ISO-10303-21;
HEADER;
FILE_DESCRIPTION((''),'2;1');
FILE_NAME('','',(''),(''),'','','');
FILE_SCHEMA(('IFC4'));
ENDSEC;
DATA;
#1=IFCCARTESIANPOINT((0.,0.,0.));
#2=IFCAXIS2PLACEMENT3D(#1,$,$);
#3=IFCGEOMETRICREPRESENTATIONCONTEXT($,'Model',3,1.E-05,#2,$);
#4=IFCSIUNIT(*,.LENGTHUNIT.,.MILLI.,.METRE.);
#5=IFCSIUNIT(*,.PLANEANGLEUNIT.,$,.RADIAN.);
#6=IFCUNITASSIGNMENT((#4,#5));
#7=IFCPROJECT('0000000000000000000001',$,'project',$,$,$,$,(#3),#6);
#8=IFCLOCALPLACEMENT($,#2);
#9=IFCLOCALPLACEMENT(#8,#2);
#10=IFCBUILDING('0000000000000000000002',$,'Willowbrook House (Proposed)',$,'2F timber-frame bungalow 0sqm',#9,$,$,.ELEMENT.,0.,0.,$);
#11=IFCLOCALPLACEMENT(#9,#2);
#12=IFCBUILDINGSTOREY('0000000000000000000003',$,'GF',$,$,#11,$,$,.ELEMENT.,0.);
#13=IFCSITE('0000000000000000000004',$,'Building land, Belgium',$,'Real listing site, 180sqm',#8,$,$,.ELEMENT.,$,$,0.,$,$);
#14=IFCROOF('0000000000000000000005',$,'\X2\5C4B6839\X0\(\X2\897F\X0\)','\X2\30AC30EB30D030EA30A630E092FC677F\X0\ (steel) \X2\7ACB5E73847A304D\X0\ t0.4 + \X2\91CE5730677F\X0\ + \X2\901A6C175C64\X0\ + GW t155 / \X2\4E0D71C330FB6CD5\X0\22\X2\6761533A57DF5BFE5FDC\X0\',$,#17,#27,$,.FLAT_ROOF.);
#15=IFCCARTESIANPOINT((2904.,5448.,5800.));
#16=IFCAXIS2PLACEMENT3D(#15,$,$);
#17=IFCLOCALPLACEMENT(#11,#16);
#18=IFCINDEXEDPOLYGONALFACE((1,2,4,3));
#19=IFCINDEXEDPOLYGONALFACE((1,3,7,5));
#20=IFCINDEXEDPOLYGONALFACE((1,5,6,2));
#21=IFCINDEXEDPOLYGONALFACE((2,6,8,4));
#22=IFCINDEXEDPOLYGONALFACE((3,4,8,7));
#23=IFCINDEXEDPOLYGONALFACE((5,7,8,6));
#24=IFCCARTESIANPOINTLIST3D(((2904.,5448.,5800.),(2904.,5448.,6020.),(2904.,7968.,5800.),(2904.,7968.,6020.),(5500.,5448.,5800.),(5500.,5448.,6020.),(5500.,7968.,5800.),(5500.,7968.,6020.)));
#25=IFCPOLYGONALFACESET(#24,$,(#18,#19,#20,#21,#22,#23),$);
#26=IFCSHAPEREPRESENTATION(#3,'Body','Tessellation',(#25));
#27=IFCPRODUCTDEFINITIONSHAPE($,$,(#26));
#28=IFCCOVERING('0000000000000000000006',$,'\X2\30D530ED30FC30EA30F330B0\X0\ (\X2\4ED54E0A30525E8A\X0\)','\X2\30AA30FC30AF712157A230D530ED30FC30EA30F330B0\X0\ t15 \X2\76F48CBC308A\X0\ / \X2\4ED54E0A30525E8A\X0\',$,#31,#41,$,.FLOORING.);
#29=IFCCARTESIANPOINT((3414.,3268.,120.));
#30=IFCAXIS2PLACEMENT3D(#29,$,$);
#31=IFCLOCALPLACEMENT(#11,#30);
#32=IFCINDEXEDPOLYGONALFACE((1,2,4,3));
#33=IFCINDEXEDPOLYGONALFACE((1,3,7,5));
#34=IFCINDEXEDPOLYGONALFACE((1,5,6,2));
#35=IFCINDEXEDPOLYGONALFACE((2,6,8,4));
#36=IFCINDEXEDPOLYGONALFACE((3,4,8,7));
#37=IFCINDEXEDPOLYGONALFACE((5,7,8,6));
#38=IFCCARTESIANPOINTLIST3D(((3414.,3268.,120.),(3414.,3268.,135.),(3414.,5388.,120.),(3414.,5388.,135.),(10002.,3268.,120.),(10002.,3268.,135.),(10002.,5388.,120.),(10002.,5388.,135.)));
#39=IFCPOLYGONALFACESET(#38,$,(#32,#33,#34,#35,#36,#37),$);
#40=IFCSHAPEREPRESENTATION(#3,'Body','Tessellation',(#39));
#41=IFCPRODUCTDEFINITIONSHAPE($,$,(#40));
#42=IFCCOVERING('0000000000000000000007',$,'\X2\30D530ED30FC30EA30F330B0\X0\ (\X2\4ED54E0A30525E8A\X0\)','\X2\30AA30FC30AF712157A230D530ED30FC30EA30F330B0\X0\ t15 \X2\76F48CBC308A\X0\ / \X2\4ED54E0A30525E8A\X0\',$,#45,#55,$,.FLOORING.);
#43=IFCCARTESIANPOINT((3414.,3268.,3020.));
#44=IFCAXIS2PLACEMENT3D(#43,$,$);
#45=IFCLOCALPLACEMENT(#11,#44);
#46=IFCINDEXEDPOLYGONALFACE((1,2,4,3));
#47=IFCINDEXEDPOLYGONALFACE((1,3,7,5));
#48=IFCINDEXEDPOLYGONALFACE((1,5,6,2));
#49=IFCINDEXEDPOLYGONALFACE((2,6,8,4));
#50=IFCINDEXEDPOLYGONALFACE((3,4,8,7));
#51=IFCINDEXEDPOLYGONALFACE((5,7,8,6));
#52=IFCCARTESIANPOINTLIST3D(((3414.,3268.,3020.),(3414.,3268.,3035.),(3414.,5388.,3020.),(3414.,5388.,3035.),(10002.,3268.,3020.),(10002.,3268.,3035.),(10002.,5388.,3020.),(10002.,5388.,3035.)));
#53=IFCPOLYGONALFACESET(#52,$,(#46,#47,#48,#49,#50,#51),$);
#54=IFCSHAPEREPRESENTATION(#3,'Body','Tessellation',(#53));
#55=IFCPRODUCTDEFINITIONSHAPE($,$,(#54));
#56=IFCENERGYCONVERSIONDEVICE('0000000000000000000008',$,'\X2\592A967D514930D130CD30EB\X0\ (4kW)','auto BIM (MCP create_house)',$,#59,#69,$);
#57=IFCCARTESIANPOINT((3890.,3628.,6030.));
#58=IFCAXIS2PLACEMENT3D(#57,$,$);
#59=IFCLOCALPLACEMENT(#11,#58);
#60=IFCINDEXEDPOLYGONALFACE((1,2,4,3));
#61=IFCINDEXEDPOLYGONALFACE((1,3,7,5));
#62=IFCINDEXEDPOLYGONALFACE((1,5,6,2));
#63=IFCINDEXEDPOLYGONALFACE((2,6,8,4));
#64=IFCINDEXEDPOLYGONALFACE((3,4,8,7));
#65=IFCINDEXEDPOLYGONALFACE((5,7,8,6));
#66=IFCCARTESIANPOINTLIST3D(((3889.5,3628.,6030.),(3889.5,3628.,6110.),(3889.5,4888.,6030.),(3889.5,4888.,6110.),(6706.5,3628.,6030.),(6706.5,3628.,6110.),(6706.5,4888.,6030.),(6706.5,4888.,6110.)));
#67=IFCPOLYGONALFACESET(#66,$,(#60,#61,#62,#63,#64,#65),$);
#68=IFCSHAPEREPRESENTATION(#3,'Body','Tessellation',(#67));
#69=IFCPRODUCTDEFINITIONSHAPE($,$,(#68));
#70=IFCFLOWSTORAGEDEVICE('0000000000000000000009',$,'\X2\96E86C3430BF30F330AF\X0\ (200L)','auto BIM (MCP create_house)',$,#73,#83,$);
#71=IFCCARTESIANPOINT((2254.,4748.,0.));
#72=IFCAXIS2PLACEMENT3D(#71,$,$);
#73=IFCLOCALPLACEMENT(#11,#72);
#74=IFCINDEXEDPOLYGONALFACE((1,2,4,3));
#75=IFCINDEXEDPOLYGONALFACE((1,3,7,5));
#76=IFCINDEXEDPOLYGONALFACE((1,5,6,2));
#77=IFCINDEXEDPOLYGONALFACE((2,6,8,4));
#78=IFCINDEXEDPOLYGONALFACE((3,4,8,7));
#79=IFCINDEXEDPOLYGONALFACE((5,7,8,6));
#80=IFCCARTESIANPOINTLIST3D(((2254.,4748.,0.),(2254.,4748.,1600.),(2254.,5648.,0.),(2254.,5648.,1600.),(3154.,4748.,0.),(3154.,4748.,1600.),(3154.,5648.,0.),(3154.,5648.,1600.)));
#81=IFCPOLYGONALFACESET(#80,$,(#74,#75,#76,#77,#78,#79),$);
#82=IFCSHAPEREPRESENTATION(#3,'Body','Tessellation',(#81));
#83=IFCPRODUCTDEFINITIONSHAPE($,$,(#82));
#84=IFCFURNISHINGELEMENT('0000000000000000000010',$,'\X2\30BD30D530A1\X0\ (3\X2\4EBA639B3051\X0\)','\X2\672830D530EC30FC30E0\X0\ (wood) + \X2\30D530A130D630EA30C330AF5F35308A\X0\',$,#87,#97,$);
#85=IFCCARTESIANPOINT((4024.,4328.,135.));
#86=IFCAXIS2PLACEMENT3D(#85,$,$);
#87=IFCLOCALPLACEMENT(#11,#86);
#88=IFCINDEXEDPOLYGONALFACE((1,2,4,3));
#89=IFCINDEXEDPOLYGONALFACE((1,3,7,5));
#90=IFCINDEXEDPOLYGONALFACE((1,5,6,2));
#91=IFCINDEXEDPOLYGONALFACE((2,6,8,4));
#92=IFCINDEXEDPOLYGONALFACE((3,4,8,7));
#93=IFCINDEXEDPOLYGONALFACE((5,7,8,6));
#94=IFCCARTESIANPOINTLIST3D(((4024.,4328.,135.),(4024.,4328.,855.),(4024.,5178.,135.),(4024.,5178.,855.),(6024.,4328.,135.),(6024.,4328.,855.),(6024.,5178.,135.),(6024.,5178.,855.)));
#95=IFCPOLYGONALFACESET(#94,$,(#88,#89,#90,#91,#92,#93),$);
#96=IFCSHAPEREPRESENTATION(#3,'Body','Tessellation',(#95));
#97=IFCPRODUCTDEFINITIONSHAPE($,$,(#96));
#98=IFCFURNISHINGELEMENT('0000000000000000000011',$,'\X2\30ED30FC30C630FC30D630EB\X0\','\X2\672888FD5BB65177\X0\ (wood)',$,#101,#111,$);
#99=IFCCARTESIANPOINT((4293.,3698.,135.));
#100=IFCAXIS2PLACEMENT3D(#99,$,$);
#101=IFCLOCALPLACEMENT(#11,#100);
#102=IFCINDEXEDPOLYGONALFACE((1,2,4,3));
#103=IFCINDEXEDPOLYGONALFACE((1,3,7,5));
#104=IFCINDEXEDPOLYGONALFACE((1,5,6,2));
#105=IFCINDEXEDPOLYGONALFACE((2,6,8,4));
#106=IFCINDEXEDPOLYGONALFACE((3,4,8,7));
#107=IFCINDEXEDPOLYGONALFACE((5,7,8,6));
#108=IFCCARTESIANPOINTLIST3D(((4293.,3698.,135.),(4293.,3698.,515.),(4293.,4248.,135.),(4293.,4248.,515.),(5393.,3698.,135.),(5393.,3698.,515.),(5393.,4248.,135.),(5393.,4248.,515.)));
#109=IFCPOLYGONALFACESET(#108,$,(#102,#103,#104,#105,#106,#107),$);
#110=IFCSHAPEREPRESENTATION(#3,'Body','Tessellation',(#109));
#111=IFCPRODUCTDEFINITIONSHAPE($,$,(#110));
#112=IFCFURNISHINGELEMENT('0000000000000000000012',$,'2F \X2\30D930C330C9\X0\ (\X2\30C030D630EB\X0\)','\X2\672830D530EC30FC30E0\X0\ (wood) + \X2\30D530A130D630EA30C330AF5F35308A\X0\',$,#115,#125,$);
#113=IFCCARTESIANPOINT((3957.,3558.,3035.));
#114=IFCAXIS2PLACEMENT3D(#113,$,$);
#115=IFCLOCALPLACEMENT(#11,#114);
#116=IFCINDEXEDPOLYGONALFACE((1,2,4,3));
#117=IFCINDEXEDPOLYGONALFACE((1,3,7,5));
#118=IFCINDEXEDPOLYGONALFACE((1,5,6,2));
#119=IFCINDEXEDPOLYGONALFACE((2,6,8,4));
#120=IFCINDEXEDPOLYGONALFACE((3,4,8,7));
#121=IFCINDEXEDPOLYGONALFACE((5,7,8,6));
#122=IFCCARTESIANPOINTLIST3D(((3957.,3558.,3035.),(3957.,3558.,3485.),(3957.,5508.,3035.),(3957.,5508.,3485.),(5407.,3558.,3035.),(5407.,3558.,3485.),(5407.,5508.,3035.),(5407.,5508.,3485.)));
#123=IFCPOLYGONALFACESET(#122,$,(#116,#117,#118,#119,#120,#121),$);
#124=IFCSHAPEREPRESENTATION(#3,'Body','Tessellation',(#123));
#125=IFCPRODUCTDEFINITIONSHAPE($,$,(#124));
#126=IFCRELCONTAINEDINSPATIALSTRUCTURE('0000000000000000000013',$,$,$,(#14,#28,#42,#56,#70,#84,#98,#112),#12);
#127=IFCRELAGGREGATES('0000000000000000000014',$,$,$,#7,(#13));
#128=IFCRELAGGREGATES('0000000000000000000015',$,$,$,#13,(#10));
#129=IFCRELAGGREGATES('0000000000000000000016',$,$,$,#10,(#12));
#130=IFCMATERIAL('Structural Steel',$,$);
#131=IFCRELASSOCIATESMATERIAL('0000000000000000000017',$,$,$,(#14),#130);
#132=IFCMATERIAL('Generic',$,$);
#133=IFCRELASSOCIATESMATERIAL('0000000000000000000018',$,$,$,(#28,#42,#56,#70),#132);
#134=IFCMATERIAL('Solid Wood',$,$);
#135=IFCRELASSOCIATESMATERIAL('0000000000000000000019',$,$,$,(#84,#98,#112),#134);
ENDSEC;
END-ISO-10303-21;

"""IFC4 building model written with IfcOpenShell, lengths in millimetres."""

from ifc_helpers import new_model, si_unit, frame, frame_2d, origin, place, context, project, spatial, rectangle, extrude, material, element, save


model = new_model("IFC4")

# Units and contexts
model_context = context("Model", 3, precision=1e-05, world=origin())
ifc_project = project(units=[si_unit("LENGTHUNIT", "METRE", prefix="MILLI"), si_unit("PLANEANGLEUNIT", "RADIAN")], contexts=[model_context])

# Site, building, storey
site_placement = place(None, origin())
site = spatial("IfcSite", under=ifc_project, at=site_placement, Name="Building land, Belgium", ObjectType="Real listing site, 180sqm", CompositionType="ELEMENT", RefElevation=0.0)
building_placement = place(site_placement, origin())
building = spatial("IfcBuilding", under=site, at=building_placement, Name="Willowbrook House (Proposed)", ObjectType="2F timber-frame bungalow 0sqm", CompositionType="ELEMENT", ElevationOfRefHeight=0.0, ElevationOfTerrain=0.0)
storey_placement = place(building_placement, origin())
storey = spatial("IfcBuildingStorey", under=building, at=storey_placement, Name="GF", CompositionType="ELEMENT", Elevation=0.0)

# Shared definitions
ifc_material_1 = material(Name="Solid Wood")

# Roof
ifc_material_2 = material(Name="Structural Steel")
roof_1_placement = place(storey_placement, frame((2904.0, 5448.0, 5800.0)))
element("IfcRoof", 1, at=roof_1_placement, inside=storey, material=ifc_material_2, Name="屋根(西)", Description="ガルバリウム鋼板 (steel) 立平葺き t0.4 + 野地板 + 通気層 + GW t155 / 不燃・法22条区域対応", PredefinedType="FLAT_ROOF", context=model_context, shape_type="SweptSolid", body=[
    extrude(rectangle(XDim=2596.0, YDim=2520.0, at=frame_2d((1298.0, 1260.0))), frame((2904.0, 5448.0, 5800.0)), (0.0, 0.0, 1.0), 220.0),
])

# Coverings
ifc_material_3 = material(Name="Generic")
covering_1_placement = place(storey_placement, frame((3414.0, 3268.0, 120.0)))
element("IfcCovering", 2, at=covering_1_placement, inside=storey, material=ifc_material_3, Name="フローリング (仕上げ床)", Description="オーク無垢フローリング t15 直貼り / 仕上げ床", PredefinedType="FLOORING", context=model_context, shape_type="SweptSolid", body=[
    extrude(rectangle(XDim=6588.0, YDim=2120.0, at=frame_2d((3294.0, 1060.0))), frame((3414.0, 3268.0, 120.0)), (0.0, 0.0, 1.0), 15.0),
])
covering_2_placement = place(storey_placement, frame((3414.0, 3268.0, 3020.0)))
element("IfcCovering", 3, at=covering_2_placement, inside=storey, material=ifc_material_3, Name="フローリング (仕上げ床)", Description="オーク無垢フローリング t15 直貼り / 仕上げ床", PredefinedType="FLOORING", context=model_context, shape_type="SweptSolid", body=[
    extrude(rectangle(XDim=6588.0, YDim=2120.0, at=frame_2d((3294.0, 1060.0))), frame((3414.0, 3268.0, 3020.0)), (0.0, 0.0, 1.0), 15.0),
])

# Energy conversion device
energy_conversion_device_placement = place(storey_placement, frame((3890.0, 3628.0, 6030.0)))
element("IfcEnergyConversionDevice", 4, at=energy_conversion_device_placement, inside=storey, material=ifc_material_3, Name="太陽光パネル (4kW)", Description="auto BIM (MCP create_house)", context=model_context, shape_type="SweptSolid", body=[
    extrude(rectangle(XDim=2817.0, YDim=1260.0, at=frame_2d((1408.0, 630.0))), frame((3890.0, 3628.0, 6030.0)), (0.0, 0.0, 1.0), 80.0),
])

# Flow storage device
flow_storage_device_placement = place(storey_placement, frame((2254.0, 4748.0, 0.0)))
element("IfcFlowStorageDevice", 5, at=flow_storage_device_placement, inside=storey, material=ifc_material_3, Name="雨水タンク (200L)", Description="auto BIM (MCP create_house)", context=model_context, shape_type="SweptSolid", body=[
    extrude(rectangle(XDim=900.0, YDim=900.0, at=frame_2d((450.0, 450.0))), frame((2254.0, 4748.0, 0.0)), (0.0, 0.0, 1.0), 1600.0),
])

# Furnishing elements
furnishing_1_placement = place(storey_placement, frame((4024.0, 4328.0, 135.0)))
element("IfcFurnishingElement", 6, at=furnishing_1_placement, inside=storey, material=ifc_material_1, Name="ソファ (3人掛け)", Description="木フレーム (wood) + ファブリック張り", context=model_context, shape_type="SweptSolid", body=[
    extrude(rectangle(XDim=2000.0, YDim=850.0, at=frame_2d((1000.0, 425.0))), frame((4024.0, 4328.0, 135.0)), (0.0, 0.0, 1.0), 720.0),
])
furnishing_2_placement = place(storey_placement, frame((4293.0, 3698.0, 135.0)))
element("IfcFurnishingElement", 7, at=furnishing_2_placement, inside=storey, material=ifc_material_1, Name="ローテーブル", Description="木製家具 (wood)", context=model_context, shape_type="SweptSolid", body=[
    extrude(rectangle(XDim=1100.0, YDim=550.0, at=frame_2d((550.0, 275.0))), frame((4293.0, 3698.0, 135.0)), (0.0, 0.0, 1.0), 380.0),
])
furnishing_3_placement = place(storey_placement, frame((3957.0, 3558.0, 3035.0)))
element("IfcFurnishingElement", 8, at=furnishing_3_placement, inside=storey, material=ifc_material_1, Name="2F ベッド (ダブル)", Description="木フレーム (wood) + ファブリック張り", context=model_context, shape_type="SweptSolid", body=[
    extrude(rectangle(XDim=1450.0, YDim=1950.0, at=frame_2d((725.0, 975.0))), frame((3957.0, 3558.0, 3035.0)), (0.0, 0.0, 1.0), 450.0),
])

save(model, "model.ifc")
